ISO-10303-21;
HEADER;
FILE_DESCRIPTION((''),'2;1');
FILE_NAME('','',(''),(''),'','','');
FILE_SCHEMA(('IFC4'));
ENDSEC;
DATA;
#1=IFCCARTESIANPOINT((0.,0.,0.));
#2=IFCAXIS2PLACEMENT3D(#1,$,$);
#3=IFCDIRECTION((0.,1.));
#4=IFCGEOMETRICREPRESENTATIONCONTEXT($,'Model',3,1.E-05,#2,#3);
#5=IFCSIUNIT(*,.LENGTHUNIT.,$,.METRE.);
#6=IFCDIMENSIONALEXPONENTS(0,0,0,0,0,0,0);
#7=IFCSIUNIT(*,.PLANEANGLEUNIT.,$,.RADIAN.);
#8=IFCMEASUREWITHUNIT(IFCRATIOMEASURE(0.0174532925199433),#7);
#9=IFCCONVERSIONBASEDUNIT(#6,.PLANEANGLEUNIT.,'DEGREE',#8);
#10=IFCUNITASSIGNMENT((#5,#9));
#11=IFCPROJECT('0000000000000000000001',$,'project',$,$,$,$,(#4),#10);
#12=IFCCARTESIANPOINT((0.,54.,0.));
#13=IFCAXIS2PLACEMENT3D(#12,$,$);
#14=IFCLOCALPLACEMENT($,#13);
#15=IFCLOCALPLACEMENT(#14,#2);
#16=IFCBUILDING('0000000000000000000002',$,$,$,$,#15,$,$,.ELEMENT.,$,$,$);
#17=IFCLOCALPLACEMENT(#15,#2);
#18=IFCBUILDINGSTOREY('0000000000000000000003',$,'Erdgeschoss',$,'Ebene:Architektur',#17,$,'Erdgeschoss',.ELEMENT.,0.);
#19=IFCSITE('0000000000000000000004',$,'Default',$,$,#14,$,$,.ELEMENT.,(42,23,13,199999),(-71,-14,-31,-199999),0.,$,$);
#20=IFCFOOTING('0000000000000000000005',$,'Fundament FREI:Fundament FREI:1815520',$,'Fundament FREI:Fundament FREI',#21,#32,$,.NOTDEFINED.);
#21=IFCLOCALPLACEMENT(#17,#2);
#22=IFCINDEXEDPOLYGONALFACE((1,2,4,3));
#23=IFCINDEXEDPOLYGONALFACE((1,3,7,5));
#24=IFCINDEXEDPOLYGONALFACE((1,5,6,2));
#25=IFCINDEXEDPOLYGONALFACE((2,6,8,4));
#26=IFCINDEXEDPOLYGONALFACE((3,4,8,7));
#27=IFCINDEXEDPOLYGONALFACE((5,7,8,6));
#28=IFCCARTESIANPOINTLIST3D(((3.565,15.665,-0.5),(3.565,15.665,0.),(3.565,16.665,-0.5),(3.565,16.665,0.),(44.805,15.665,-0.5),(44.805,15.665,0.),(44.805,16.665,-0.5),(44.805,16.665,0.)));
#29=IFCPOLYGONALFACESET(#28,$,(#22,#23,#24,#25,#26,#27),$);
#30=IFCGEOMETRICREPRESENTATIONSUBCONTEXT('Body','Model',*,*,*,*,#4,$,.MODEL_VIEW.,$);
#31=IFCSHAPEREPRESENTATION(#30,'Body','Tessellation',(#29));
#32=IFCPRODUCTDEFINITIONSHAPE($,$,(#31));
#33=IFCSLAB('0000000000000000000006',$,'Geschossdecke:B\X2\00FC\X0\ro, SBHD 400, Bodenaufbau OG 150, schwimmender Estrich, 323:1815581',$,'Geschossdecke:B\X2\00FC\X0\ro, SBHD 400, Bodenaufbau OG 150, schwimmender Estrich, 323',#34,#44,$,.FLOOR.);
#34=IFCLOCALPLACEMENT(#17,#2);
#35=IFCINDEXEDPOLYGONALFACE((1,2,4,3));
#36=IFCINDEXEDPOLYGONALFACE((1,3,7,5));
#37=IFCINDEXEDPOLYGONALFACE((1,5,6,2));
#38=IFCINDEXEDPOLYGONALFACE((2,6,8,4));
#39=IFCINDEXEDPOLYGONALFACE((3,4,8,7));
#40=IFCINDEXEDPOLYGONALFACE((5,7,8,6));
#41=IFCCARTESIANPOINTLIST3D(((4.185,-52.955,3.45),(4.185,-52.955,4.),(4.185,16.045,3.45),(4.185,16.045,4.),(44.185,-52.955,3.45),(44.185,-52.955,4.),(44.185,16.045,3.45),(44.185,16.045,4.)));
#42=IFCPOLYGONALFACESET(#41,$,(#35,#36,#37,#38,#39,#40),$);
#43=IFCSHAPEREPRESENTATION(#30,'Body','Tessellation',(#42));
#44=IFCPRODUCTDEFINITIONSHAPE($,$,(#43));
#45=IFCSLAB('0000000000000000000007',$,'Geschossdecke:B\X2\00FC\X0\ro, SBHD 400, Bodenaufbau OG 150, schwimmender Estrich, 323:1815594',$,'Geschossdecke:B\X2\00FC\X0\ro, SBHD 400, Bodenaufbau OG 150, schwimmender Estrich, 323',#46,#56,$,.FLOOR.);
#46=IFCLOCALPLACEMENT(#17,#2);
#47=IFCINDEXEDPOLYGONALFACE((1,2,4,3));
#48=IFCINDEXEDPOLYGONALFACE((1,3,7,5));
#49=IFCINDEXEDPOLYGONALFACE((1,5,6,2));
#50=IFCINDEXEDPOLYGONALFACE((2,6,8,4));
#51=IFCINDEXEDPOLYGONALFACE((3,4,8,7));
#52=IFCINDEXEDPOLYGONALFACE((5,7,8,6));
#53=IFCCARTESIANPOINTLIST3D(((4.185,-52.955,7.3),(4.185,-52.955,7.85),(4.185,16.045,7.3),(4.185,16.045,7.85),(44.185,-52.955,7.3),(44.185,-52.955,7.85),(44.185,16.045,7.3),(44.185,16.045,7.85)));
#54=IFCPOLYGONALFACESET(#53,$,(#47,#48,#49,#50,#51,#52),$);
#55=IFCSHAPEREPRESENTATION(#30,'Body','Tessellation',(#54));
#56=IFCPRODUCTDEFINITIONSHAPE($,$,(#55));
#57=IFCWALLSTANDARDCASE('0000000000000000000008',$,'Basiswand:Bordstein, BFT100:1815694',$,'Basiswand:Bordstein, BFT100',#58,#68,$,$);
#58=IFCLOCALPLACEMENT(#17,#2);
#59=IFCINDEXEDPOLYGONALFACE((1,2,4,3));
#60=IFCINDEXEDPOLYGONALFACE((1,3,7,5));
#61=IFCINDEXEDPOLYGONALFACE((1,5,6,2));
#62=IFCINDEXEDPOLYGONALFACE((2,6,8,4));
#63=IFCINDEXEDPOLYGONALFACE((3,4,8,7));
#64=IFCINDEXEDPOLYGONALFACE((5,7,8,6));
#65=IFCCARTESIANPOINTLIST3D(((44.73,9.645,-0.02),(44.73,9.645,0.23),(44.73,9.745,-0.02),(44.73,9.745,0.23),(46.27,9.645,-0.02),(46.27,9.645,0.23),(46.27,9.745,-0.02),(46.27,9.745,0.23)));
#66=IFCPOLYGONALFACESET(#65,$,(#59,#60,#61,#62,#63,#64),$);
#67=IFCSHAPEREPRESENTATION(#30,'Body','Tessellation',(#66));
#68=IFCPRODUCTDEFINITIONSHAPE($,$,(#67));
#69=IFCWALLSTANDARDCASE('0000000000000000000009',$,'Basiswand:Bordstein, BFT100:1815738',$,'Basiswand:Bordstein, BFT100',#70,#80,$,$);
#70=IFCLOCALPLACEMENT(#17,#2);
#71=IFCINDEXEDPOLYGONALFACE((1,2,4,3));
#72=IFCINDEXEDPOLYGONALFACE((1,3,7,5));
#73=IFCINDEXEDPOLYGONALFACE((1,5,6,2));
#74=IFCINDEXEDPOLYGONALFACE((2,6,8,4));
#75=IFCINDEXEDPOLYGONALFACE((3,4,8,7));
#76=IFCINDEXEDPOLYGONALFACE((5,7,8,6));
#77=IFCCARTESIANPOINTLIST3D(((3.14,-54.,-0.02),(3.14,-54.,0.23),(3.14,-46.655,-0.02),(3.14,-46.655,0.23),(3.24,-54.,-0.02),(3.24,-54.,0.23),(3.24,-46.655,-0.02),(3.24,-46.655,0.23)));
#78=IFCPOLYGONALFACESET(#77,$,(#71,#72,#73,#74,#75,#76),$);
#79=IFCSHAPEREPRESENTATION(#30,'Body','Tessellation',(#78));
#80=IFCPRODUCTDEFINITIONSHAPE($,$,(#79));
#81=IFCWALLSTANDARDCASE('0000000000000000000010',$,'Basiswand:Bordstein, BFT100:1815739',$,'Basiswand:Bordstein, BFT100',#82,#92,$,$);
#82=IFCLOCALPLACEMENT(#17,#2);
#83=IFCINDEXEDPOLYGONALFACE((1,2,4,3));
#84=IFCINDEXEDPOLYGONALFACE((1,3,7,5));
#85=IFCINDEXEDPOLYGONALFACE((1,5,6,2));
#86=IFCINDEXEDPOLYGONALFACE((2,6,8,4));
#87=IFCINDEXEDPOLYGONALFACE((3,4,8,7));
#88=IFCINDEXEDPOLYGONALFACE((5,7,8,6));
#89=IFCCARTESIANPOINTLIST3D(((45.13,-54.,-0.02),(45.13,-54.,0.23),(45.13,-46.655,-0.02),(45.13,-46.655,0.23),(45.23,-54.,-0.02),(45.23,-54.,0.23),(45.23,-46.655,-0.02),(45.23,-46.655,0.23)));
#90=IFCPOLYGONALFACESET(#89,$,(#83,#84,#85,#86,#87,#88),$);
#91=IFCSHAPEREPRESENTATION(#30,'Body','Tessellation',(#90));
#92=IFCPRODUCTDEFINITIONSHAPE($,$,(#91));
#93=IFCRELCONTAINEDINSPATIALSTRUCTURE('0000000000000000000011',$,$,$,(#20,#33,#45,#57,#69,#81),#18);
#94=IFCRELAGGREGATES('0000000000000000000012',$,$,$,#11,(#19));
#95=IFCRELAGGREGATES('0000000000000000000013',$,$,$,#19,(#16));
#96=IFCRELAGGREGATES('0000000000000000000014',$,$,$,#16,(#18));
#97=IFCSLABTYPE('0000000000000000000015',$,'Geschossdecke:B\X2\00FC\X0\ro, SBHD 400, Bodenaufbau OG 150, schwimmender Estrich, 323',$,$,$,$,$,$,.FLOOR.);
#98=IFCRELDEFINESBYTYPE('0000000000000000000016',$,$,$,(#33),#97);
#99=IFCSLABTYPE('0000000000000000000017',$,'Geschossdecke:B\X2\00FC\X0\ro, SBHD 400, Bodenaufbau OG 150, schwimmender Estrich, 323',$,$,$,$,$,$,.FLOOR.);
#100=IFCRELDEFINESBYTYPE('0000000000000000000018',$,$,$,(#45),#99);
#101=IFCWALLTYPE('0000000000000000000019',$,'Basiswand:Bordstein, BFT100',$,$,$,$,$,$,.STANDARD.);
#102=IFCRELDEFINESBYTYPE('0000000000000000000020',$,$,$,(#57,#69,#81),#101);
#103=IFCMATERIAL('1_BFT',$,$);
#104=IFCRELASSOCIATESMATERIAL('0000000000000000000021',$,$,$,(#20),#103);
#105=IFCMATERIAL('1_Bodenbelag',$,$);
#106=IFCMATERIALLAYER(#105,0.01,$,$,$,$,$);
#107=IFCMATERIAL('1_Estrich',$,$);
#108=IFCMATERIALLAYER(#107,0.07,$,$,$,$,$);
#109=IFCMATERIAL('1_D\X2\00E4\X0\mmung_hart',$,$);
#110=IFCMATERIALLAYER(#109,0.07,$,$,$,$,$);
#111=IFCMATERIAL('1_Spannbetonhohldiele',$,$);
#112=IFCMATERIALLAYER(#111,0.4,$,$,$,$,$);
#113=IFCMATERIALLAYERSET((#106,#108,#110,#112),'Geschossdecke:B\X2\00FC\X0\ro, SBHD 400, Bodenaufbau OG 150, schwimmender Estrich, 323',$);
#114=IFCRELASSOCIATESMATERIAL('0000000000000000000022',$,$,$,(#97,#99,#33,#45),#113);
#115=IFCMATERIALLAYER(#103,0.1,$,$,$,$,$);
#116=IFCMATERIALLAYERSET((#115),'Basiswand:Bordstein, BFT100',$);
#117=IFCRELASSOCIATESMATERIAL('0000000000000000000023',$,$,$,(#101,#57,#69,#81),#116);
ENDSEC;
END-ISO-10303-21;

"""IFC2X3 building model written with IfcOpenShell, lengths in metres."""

from ifc_helpers import new_model, entity, si_unit, converted_unit, direction, frame, frame_2d, origin, place, context, subcontext, project, spatial, rectangle, extrude, source, transform, mapped, material, layer, layer_set, layer_usage, type_object, element, save


model = new_model("IFC2X3")

# Units and contexts
model_context = context("Model", 3, precision=1e-05, world=origin(), true_north=direction((0.0, 1.0)))
body_context = subcontext(model_context, "Body", "Model", "MODEL_VIEW")
ifc_project = project(units=[si_unit("LENGTHUNIT", "METRE"), converted_unit("PLANEANGLEUNIT", "DEGREE", entity("IfcRatioMeasure", 0.0174532925199433), si_unit("PLANEANGLEUNIT", "RADIAN"), dimensions=[0, 0, 0, 0, 0, 0, 0])], contexts=[model_context])

# Site, building, storey
site_placement = place(None, frame((0.0, 54.0, 0.0)))
site = spatial("IfcSite", under=ifc_project, at=site_placement, Name="Default", CompositionType="ELEMENT", RefLatitude=(42, 23, 13, 199999), RefLongitude=(-71, -14, -31, -199999), RefElevation=0.0)
building_placement = place(site_placement, origin())
building = spatial("IfcBuilding", under=site, at=building_placement, CompositionType="ELEMENT")
storey_placement = place(building_placement, origin())
storey = spatial("IfcBuildingStorey", under=building, at=storey_placement, Name="Erdgeschoss", ObjectType="Ebene:Architektur", LongName="Erdgeschoss", CompositionType="ELEMENT", Elevation=0.0)

# Footing
ifc_material_1 = material(Name="1_BFT")
shared_shape = source(origin(), body_context, "Body", "SweptSolid", [
    extrude(rectangle(XDim=41.24, YDim=1.0, at=frame_2d((0.0, 0.0), x_axis=(1.0, 0.0))), frame((24.185, 16.165, -0.5)), (0.0, 0.0, 1.0), 0.5),
])
footing_placement = place(storey_placement, origin())
element("IfcFooting", 1, at=footing_placement, inside=storey, material=ifc_material_1, Name="Fundament FREI:Fundament FREI:1815520", ObjectType="Fundament FREI:Fundament FREI", PredefinedType="NOTDEFINED", context=body_context, shape_type="MappedRepresentation", body=[
    mapped(shared_shape, transform((0.0, 0.0, 0.0), scale=1.0)),
])

# Slabs
ifc_material_2 = material(Name="1_Bodenbelag")
ifc_layer_1 = layer(ifc_material_2, 0.01)
ifc_material_3 = material(Name="1_Estrich")
ifc_layer_2 = layer(ifc_material_3, 0.07)
ifc_material_4 = material(Name="1_Dämmung_hart")
ifc_layer_3 = layer(ifc_material_4, 0.07)
ifc_material_5 = material(Name="1_Spannbetonhohldiele")
ifc_layer_4 = layer(ifc_material_5, 0.4)
ifc_layer_set_1 = layer_set([ifc_layer_1, ifc_layer_2, ifc_layer_3, ifc_layer_4], Name="Geschossdecke:Büro, SBHD 400, Bodenaufbau OG 150, schwimmender Estrich, 323")
ifc_layer_usage_1 = layer_usage(ifc_layer_set_1, "AXIS3", "POSITIVE", 0.0)
slab_type_1 = type_object("IfcSlabType", Name="Geschossdecke:Büro, SBHD 400, Bodenaufbau OG 150, schwimmender Estrich, 323", PredefinedType="FLOOR", material=ifc_layer_set_1)
slab_1_placement = place(storey_placement, origin())
element("IfcSlab", 2, at=slab_1_placement, inside=storey, type_object=slab_type_1, material=ifc_layer_usage_1, Name="Geschossdecke:Büro, SBHD 400, Bodenaufbau OG 150, schwimmender Estrich, 323:1815581", ObjectType="Geschossdecke:Büro, SBHD 400, Bodenaufbau OG 150, schwimmender Estrich, 323", PredefinedType="FLOOR", context=body_context, shape_type="SweptSolid", body=[
    extrude(rectangle(XDim=69.0, YDim=40.0, at=frame_2d((0.0, 0.0), x_axis=(1.0, 0.0))), frame((24.185, -18.455, 4.0), z_axis=(0.0, 0.0, -1.0), x_axis=(0.0, 1.0, 0.0)), (0.0, 0.0, 1.0), 0.55),
])
ifc_layer_usage_2 = layer_usage(ifc_layer_set_1, "AXIS3", "POSITIVE", 0.0)
slab_type_2 = type_object("IfcSlabType", Name="Geschossdecke:Büro, SBHD 400, Bodenaufbau OG 150, schwimmender Estrich, 323", PredefinedType="FLOOR", material=ifc_layer_set_1)
slab_2_placement = place(storey_placement, origin())
element("IfcSlab", 3, at=slab_2_placement, inside=storey, type_object=slab_type_2, material=ifc_layer_usage_2, Name="Geschossdecke:Büro, SBHD 400, Bodenaufbau OG 150, schwimmender Estrich, 323:1815594", ObjectType="Geschossdecke:Büro, SBHD 400, Bodenaufbau OG 150, schwimmender Estrich, 323", PredefinedType="FLOOR", context=body_context, shape_type="SweptSolid", body=[
    extrude(rectangle(XDim=69.0, YDim=40.0, at=frame_2d((0.0, 0.0), x_axis=(1.0, 0.0))), frame((24.185, -18.455, 7.85), z_axis=(0.0, 0.0, -1.0), x_axis=(0.0, 1.0, 0.0)), (0.0, 0.0, 1.0), 0.55),
])

# Walls
ifc_layer_5 = layer(ifc_material_1, 0.1)
ifc_layer_set_2 = layer_set([ifc_layer_5], Name="Basiswand:Bordstein, BFT100")
ifc_layer_usage_3 = layer_usage(ifc_layer_set_2, "AXIS2", "NEGATIVE", 0.05)
wall_type = type_object("IfcWallType", Name="Basiswand:Bordstein, BFT100", PredefinedType="STANDARD", material=ifc_layer_set_2)
wall_1_placement = place(storey_placement, frame((44.73, 9.695, -0.02)))
element("IfcWallStandardCase", 4, at=wall_1_placement, inside=storey, type_object=wall_type, material=ifc_layer_usage_3, Name="Basiswand:Bordstein, BFT100:1815694", ObjectType="Basiswand:Bordstein, BFT100", context=body_context, shape_type="SweptSolid", body=[
    extrude(rectangle(XDim=1.54, YDim=0.1, at=frame_2d((0.77, 0.0), x_axis=(-1.0, 0.0))), origin(), (0.0, 0.0, 1.0), 0.25),
])
ifc_layer_usage_4 = layer_usage(ifc_layer_set_2, "AXIS2", "POSITIVE", -0.05)
wall_2_placement = place(storey_placement, frame((3.19, -46.655, -0.02), z_axis=(0.0, 0.0, 1.0), x_axis=(0.0, -1.0, 0.0)))
element("IfcWallStandardCase", 5, at=wall_2_placement, inside=storey, type_object=wall_type, material=ifc_layer_usage_4, Name="Basiswand:Bordstein, BFT100:1815738", ObjectType="Basiswand:Bordstein, BFT100", context=body_context, shape_type="SweptSolid", body=[
    extrude(rectangle(XDim=7.345, YDim=0.1, at=frame_2d((3.6725, 0.0), x_axis=(-1.0, 0.0))), origin(), (0.0, 0.0, 1.0), 0.25),
])
ifc_layer_usage_5 = layer_usage(ifc_layer_set_2, "AXIS2", "NEGATIVE", 0.05)
wall_3_placement = place(storey_placement, frame((45.18, -46.655, -0.02), z_axis=(0.0, 0.0, 1.0), x_axis=(0.0, -1.0, 0.0)))
element("IfcWallStandardCase", 6, at=wall_3_placement, inside=storey, type_object=wall_type, material=ifc_layer_usage_5, Name="Basiswand:Bordstein, BFT100:1815739", ObjectType="Basiswand:Bordstein, BFT100", context=body_context, shape_type="SweptSolid", body=[
    extrude(rectangle(XDim=7.345, YDim=0.1, at=frame_2d((3.6725, 0.0), x_axis=(-1.0, 0.0))), origin(), (0.0, 0.0, 1.0), 0.25),
])

save(model, "model.ifc")
